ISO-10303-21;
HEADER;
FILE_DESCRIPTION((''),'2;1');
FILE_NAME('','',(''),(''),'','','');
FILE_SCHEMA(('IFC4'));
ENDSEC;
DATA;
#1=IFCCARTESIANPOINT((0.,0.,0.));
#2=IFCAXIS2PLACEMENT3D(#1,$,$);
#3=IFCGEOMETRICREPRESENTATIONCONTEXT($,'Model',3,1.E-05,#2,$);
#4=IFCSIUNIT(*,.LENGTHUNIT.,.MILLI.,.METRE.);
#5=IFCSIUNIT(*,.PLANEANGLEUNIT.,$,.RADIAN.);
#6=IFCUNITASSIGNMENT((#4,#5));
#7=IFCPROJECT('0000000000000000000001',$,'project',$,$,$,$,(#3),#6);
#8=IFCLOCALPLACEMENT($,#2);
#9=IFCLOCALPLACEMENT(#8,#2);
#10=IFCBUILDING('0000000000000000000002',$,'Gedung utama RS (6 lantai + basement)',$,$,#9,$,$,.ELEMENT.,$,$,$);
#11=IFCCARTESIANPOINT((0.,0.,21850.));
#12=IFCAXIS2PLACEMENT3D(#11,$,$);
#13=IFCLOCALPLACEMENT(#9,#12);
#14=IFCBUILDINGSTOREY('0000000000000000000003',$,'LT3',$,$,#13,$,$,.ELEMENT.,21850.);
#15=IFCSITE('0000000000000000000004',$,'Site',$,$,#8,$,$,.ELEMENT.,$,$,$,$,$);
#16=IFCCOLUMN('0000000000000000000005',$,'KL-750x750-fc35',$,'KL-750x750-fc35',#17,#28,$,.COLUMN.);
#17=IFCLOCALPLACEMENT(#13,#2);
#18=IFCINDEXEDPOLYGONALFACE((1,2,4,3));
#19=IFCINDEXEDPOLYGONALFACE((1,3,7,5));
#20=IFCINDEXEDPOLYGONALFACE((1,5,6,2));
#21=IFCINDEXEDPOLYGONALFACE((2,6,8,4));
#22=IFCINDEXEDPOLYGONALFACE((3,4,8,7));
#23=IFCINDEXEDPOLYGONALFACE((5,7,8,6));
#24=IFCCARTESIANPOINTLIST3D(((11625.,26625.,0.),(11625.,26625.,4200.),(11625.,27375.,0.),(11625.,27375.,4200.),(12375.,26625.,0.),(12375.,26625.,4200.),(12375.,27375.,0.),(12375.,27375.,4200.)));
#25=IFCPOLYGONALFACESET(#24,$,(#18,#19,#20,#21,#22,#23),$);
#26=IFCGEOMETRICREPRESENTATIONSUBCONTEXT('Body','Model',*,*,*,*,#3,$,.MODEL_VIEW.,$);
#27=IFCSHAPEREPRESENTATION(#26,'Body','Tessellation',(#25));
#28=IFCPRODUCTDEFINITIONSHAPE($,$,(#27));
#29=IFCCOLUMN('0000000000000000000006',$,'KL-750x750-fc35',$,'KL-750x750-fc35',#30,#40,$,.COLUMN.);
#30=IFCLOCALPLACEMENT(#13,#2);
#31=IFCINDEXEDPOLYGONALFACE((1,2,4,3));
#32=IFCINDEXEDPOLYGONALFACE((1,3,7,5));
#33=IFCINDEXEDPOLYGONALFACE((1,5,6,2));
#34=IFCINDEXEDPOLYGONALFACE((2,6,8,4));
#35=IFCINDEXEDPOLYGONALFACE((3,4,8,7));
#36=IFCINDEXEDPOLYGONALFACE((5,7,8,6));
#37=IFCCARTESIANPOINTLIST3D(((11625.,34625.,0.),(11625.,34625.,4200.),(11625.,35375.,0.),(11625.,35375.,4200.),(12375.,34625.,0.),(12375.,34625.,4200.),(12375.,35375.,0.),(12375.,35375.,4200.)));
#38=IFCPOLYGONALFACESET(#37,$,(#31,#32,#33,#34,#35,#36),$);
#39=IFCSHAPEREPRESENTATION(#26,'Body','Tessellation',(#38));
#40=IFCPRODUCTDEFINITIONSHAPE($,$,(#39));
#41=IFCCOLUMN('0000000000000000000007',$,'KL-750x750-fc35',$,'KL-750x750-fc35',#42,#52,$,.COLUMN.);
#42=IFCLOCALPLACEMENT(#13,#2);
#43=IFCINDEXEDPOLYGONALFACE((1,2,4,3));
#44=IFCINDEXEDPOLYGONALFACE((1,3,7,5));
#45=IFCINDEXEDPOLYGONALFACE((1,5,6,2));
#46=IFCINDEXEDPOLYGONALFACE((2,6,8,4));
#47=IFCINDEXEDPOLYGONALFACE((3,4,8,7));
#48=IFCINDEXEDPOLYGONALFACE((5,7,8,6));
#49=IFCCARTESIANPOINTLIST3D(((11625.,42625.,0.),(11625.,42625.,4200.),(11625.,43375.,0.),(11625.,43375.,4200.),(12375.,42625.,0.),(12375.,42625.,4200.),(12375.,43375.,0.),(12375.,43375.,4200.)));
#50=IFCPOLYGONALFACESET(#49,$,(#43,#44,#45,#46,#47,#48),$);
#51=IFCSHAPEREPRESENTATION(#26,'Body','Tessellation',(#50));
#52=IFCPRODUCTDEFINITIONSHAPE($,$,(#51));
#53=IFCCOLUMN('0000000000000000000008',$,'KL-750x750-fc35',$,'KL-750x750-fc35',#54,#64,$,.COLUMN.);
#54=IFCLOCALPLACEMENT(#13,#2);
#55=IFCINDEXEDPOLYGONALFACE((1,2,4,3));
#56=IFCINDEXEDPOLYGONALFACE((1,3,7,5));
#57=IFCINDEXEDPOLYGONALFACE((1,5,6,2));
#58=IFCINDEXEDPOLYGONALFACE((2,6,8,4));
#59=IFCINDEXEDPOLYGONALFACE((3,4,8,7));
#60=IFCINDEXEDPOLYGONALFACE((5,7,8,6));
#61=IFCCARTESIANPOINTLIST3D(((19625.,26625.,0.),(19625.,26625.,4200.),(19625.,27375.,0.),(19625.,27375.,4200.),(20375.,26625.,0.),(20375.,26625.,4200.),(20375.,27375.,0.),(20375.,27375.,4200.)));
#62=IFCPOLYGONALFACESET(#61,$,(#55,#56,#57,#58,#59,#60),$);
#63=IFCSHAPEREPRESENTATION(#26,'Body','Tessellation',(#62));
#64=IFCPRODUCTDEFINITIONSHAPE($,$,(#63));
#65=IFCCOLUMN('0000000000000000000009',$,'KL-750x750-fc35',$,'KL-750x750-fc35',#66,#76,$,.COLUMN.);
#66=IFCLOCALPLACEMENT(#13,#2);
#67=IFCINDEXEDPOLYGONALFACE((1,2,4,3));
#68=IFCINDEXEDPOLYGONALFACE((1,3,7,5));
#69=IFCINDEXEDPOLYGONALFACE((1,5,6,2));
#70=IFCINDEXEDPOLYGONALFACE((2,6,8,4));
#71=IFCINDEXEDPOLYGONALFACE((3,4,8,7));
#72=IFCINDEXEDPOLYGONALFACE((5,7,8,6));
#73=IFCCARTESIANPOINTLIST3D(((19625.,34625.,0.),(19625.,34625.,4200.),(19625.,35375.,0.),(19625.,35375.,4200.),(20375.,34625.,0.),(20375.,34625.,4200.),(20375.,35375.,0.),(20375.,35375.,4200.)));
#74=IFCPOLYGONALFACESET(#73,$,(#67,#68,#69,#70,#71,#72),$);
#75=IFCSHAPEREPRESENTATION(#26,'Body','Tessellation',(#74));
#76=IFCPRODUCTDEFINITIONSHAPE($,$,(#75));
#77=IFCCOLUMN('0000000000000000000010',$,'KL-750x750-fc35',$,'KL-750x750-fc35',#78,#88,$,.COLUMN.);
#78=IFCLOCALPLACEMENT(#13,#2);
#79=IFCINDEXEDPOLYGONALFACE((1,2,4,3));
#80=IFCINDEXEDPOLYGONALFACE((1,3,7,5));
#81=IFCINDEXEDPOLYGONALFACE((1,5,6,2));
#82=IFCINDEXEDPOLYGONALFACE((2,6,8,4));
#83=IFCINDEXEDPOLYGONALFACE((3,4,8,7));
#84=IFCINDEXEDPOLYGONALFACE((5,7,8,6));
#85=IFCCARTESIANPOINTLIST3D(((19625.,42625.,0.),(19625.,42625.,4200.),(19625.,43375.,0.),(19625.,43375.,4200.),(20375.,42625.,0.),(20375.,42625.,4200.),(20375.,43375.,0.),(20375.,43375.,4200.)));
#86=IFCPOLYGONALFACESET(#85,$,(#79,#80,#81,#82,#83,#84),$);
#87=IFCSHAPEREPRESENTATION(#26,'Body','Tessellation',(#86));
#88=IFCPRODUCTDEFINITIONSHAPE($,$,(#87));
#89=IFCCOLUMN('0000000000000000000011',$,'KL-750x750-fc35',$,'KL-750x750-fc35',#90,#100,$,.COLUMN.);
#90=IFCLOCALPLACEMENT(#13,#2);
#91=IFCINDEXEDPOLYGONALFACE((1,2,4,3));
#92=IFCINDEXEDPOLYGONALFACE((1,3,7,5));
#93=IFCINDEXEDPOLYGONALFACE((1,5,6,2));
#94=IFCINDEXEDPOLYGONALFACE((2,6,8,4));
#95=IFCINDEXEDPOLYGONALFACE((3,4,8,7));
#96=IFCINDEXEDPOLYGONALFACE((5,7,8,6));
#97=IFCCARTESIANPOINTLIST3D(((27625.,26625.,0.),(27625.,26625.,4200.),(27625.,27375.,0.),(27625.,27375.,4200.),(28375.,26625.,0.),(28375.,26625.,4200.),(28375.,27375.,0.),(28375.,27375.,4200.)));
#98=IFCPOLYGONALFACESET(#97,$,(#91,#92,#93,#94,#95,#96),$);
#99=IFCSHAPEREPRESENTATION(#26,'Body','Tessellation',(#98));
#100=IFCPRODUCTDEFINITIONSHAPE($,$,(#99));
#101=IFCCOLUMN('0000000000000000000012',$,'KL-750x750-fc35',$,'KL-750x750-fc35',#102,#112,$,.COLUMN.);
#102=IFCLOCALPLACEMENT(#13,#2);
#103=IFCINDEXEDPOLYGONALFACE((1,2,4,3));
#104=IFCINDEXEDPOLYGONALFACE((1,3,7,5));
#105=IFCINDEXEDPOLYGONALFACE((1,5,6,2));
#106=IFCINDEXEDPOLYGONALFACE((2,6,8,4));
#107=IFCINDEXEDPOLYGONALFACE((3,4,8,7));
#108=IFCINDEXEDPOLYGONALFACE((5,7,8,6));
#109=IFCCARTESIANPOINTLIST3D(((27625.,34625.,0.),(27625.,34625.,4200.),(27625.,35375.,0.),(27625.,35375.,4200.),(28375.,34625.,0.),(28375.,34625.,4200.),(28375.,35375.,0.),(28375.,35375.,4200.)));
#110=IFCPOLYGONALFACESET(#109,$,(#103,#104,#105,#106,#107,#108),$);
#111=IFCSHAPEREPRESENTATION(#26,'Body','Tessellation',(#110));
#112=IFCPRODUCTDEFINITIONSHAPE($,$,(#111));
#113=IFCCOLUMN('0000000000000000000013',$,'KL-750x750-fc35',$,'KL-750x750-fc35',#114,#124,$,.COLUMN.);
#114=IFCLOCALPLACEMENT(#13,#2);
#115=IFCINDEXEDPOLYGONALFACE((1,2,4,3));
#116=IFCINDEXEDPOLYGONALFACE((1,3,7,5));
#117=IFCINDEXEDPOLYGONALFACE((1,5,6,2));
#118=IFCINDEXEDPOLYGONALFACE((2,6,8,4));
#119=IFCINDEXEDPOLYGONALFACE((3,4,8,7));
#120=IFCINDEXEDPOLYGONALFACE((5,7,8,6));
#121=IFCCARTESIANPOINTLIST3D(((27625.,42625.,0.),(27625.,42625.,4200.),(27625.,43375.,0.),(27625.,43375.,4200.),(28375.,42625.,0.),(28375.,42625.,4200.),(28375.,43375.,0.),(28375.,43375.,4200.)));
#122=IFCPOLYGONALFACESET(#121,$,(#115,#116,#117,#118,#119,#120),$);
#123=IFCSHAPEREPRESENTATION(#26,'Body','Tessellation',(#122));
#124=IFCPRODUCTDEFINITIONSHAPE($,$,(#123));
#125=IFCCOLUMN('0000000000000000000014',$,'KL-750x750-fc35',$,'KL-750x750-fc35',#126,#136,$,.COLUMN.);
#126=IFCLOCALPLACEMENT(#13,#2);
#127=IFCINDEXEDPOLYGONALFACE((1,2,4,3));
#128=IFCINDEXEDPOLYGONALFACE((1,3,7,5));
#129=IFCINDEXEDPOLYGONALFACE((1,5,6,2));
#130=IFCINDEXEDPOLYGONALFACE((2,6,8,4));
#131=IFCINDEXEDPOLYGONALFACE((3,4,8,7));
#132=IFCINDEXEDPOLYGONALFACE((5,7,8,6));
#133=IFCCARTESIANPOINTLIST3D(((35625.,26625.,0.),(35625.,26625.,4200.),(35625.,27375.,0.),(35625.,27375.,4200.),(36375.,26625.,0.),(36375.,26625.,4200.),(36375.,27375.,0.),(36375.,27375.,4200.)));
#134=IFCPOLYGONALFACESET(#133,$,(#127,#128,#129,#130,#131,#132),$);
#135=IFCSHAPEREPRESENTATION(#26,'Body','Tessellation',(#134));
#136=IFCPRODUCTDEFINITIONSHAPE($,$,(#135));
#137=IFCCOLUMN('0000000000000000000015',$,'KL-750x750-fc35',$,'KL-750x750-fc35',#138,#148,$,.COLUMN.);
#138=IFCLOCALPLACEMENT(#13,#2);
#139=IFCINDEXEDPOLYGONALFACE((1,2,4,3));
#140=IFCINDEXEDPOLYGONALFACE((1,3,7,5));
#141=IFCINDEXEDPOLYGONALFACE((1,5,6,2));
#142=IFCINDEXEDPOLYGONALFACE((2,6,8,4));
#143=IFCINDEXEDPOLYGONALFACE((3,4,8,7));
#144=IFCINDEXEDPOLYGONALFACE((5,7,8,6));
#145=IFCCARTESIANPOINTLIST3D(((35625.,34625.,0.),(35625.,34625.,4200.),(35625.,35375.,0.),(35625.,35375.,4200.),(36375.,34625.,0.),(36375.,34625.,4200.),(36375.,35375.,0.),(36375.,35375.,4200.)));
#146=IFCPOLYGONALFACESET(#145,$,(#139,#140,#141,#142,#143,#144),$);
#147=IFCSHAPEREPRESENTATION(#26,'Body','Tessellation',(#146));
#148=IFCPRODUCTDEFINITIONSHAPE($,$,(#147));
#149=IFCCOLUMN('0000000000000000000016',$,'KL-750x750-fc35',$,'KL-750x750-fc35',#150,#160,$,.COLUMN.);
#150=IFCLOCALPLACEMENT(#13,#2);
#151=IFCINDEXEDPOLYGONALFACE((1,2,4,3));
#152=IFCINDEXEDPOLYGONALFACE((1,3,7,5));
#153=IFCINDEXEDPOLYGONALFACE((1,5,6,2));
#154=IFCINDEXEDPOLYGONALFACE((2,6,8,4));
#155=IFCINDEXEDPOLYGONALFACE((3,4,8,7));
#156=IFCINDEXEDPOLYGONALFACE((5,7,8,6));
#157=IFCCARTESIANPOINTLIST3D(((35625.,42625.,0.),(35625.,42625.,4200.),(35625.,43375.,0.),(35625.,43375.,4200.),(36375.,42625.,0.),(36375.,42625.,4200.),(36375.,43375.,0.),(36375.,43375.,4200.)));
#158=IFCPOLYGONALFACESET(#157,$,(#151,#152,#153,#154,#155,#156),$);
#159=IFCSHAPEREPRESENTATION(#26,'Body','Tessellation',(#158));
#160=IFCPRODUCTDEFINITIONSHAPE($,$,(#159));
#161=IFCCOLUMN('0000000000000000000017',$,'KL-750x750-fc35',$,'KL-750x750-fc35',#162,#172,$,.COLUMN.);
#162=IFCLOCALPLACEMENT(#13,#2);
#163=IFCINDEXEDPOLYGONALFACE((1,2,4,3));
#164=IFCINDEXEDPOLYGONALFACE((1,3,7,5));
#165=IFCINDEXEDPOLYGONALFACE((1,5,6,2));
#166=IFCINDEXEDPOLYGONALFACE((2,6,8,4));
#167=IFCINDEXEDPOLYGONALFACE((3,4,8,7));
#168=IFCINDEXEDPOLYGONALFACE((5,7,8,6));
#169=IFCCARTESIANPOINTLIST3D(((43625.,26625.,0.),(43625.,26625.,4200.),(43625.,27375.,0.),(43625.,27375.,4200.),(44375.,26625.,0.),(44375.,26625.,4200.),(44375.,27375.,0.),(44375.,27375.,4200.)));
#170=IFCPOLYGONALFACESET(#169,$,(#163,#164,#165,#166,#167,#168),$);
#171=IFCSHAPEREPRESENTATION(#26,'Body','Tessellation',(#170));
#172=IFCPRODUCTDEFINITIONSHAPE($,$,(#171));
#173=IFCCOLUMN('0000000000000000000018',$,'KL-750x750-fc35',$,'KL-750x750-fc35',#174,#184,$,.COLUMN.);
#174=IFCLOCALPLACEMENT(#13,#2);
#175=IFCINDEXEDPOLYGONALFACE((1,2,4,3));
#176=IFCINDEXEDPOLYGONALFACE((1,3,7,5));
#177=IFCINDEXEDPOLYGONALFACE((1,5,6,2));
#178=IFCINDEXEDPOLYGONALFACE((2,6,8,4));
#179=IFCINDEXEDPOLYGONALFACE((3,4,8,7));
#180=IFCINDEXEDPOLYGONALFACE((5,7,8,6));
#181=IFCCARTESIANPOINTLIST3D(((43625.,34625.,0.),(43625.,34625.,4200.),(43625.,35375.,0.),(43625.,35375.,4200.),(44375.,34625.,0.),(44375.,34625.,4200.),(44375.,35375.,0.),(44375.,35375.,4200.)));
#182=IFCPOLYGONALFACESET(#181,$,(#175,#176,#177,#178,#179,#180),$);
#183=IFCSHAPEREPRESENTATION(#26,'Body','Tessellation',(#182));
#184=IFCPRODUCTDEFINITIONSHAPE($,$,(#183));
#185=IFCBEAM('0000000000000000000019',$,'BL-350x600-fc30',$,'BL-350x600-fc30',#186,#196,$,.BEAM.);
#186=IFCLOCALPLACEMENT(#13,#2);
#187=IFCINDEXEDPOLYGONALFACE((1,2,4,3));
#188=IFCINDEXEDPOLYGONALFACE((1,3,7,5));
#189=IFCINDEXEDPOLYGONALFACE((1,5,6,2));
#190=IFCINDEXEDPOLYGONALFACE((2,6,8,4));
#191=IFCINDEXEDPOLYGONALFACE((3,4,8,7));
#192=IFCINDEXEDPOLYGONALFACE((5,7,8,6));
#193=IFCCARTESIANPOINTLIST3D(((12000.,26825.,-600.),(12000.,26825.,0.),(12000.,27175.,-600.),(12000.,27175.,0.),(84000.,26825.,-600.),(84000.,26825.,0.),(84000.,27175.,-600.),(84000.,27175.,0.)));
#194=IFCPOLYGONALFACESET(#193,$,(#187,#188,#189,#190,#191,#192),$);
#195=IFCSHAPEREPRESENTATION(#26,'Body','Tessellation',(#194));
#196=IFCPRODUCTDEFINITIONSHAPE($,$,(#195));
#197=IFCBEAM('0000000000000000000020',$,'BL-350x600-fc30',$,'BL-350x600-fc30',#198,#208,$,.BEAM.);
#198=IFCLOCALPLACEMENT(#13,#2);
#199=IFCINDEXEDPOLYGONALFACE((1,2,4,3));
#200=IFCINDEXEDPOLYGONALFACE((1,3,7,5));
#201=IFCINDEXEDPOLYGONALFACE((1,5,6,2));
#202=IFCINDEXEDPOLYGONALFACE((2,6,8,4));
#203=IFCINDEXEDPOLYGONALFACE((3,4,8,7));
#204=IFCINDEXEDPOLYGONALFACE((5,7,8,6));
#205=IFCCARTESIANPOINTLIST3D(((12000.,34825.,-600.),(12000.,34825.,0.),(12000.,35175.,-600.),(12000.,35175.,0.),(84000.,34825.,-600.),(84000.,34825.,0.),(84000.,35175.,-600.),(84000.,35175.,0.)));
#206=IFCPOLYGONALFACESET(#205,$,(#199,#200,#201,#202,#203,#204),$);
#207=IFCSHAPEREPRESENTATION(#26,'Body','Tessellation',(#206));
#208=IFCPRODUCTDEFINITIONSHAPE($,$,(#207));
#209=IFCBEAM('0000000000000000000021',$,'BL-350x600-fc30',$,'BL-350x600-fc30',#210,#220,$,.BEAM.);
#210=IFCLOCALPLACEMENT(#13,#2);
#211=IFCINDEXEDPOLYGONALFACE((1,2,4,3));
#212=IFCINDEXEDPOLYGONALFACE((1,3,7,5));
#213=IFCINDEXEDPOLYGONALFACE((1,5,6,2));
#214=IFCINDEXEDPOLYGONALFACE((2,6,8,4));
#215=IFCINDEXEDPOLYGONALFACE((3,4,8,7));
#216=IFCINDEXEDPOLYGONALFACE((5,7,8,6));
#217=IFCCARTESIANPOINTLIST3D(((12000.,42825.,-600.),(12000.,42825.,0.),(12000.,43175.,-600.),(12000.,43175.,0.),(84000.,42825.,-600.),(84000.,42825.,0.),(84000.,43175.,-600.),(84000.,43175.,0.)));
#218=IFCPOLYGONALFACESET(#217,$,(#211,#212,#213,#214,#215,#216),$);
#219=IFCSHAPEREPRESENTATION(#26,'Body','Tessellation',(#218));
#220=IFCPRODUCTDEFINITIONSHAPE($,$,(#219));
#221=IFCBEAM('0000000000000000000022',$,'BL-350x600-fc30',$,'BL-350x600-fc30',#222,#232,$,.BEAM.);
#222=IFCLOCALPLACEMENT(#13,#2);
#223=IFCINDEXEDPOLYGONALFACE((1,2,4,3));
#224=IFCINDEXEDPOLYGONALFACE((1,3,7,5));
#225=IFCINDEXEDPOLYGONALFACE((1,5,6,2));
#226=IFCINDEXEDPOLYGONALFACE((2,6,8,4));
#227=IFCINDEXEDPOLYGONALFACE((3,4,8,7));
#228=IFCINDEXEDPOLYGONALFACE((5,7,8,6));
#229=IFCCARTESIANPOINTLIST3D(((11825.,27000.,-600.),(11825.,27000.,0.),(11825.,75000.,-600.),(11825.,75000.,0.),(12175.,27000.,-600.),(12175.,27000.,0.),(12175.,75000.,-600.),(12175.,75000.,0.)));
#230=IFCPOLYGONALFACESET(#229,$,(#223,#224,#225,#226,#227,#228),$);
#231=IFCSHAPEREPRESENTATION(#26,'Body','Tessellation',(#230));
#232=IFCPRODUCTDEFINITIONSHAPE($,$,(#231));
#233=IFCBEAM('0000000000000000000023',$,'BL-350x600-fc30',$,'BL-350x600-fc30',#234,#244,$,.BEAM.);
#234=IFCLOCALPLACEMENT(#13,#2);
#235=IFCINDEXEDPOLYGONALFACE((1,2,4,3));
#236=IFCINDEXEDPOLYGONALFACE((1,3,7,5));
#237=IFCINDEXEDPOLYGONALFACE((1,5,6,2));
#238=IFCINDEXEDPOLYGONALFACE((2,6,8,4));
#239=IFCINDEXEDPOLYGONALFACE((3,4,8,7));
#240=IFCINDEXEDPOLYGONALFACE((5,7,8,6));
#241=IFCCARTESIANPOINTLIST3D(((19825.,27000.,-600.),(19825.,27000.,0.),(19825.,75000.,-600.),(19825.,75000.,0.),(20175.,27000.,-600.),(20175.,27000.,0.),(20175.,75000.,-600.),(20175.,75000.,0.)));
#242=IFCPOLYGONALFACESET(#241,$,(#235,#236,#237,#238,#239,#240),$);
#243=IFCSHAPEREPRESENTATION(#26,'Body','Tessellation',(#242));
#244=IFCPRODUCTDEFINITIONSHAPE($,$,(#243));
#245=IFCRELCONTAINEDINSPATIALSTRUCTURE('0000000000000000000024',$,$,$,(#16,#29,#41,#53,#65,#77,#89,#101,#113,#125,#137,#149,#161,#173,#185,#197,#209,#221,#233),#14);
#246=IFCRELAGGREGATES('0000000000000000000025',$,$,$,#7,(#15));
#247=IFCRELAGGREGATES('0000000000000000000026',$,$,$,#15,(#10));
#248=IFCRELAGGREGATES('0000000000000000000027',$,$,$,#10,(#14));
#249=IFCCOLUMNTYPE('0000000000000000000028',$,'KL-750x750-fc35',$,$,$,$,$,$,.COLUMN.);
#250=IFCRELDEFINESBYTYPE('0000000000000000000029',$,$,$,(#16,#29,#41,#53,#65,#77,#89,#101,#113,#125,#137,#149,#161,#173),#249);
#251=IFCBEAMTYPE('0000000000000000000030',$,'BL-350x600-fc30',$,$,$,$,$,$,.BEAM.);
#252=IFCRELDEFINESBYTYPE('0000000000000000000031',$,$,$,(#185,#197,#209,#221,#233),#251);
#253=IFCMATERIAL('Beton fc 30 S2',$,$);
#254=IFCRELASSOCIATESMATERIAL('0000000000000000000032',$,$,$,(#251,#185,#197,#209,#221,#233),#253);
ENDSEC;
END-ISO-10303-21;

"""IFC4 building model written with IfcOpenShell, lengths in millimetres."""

from ifc_helpers import new_model, si_unit, frame, origin, origin_2d, place, context, subcontext, project, spatial, rectangle, extrude, material, material_profile, profile_set, profile_usage, type_object, element, save


model = new_model("IFC4")

# Units and contexts
model_context = context("Model", 3, precision=1e-05, world=origin())
body_context = subcontext(model_context, "Body", "Model", "MODEL_VIEW")
ifc_project = project(units=[si_unit("LENGTHUNIT", "METRE", prefix="MILLI"), si_unit("PLANEANGLEUNIT", "RADIAN")], contexts=[model_context])

# Site, building, storey
site_placement = place(None, origin())
site = spatial("IfcSite", under=ifc_project, at=site_placement, Name="Site", CompositionType="ELEMENT")
building_placement = place(site_placement, origin())
building = spatial("IfcBuilding", under=site, at=building_placement, Name="Gedung utama RS (6 lantai + basement)", CompositionType="ELEMENT")
storey_placement = place(building_placement, frame((0.0, 0.0, 21850.0)))
storey = spatial("IfcBuildingStorey", under=building, at=storey_placement, Name="LT3", CompositionType="ELEMENT", Elevation=21850.0)

# Columns
ifc_material_profile_1 = material_profile(None, rectangle(XDim=750.0, YDim=750.0, at=origin_2d()), Name="KL-750x750-fc35")
ifc_profile_set_1 = profile_set([ifc_material_profile_1], Name="KL-750x750-fc35")
ifc_profile_usage_1 = profile_usage(ifc_profile_set_1, cardinal=5)
column_type = type_object("IfcColumnType", Name="KL-750x750-fc35", PredefinedType="COLUMN", material=ifc_profile_set_1)
for number, where, z_axis, x_axis, name in (
    (1, (12000.0, 27000.0, 0.0), (0.0, 0.0, 1.0), (1.0, 0.0, 0.0), "KL-750x750-fc35"),
    (2, (12000.0, 35000.0, 0.0), (0.0, 0.0, 1.0), (1.0, 0.0, 0.0), "KL-750x750-fc35"),
    (3, (12000.0, 43000.0, 0.0), (0.0, 0.0, 1.0), (1.0, 0.0, 0.0), "KL-750x750-fc35"),
    (4, (20000.0, 27000.0, 0.0), (0.0, 0.0, 1.0), (1.0, 0.0, 0.0), "KL-750x750-fc35"),
    (5, (20000.0, 35000.0, 0.0), (0.0, 0.0, 1.0), (1.0, 0.0, 0.0), "KL-750x750-fc35"),
    (6, (20000.0, 43000.0, 0.0), (0.0, 0.0, 1.0), (1.0, 0.0, 0.0), "KL-750x750-fc35"),
    (7, (28000.0, 27000.0, 0.0), (0.0, 0.0, 1.0), (1.0, 0.0, 0.0), "KL-750x750-fc35"),
    (8, (28000.0, 35000.0, 0.0), (0.0, 0.0, 1.0), (1.0, 0.0, 0.0), "KL-750x750-fc35"),
    (9, (28000.0, 43000.0, 0.0), (0.0, 0.0, 1.0), (1.0, 0.0, 0.0), "KL-750x750-fc35"),
    (10, (36000.0, 27000.0, 0.0), (0.0, 0.0, 1.0), (1.0, 0.0, 0.0), "KL-750x750-fc35"),
    (11, (36000.0, 35000.0, 0.0), (0.0, 0.0, 1.0), (1.0, 0.0, 0.0), "KL-750x750-fc35"),
    (12, (36000.0, 43000.0, 0.0), (0.0, 0.0, 1.0), (1.0, 0.0, 0.0), "KL-750x750-fc35"),
    (13, (44000.0, 27000.0, 0.0), (0.0, 0.0, 1.0), (1.0, 0.0, 0.0), "KL-750x750-fc35"),
    (14, (44000.0, 35000.0, 0.0), (0.0, 0.0, 1.0), (1.0, 0.0, 0.0), "KL-750x750-fc35"),
):
    element("IfcColumn", number, at=place(storey_placement, frame(where, z_axis=z_axis, x_axis=x_axis)), inside=storey, type_object=column_type, material=ifc_profile_usage_1, Name=name, ObjectType="KL-750x750-fc35", PredefinedType="COLUMN", context=body_context, shape_type="SweptSolid", body=[
        extrude(rectangle(XDim=750.0, YDim=750.0, at=origin_2d()), origin(), (0.0, 0.0, 1.0), 4200.0),
    ])

# Beams
ifc_material = material(Name="Beton fc 30 S2")
ifc_material_profile_2 = material_profile(ifc_material, rectangle(XDim=350.0, YDim=600.0, at=origin_2d()), Name="BL-350x600-fc30")
ifc_profile_set_2 = profile_set([ifc_material_profile_2], Name="BL-350x600-fc30")
ifc_profile_usage_2 = profile_usage(ifc_profile_set_2, cardinal=8)
beam_type = type_object("IfcBeamType", Name="BL-350x600-fc30", PredefinedType="BEAM", material=ifc_profile_set_2)
for number, where, name in (
    (15, (12000.0, 27000.0, -300.0), "BL-350x600-fc30"),
    (16, (12000.0, 35000.0, -300.0), "BL-350x600-fc30"),
    (17, (12000.0, 43000.0, -300.0), "BL-350x600-fc30"),
):
    element("IfcBeam", number, at=place(storey_placement, frame(where)), inside=storey, type_object=beam_type, material=ifc_profile_usage_2, Name=name, ObjectType="BL-350x600-fc30", PredefinedType="BEAM", context=body_context, shape_type="SweptSolid", body=[
        extrude(rectangle(XDim=350.0, YDim=600.0, at=origin_2d()), frame((0.0, 0.0, 0.0), z_axis=(1.0, 0.0, 0.0), x_axis=(0.0, 1.0, 0.0)), (0.0, 0.0, 1.0), 72000.0),
    ])
for number, where, name in (
    (18, (12000.0, 27000.0, -300.0), "BL-350x600-fc30"),
    (19, (20000.0, 27000.0, -300.0), "BL-350x600-fc30"),
):
    element("IfcBeam", number, at=place(storey_placement, frame(where)), inside=storey, type_object=beam_type, material=ifc_profile_usage_2, Name=name, ObjectType="BL-350x600-fc30", PredefinedType="BEAM", context=body_context, shape_type="SweptSolid", body=[
        extrude(rectangle(XDim=350.0, YDim=600.0, at=origin_2d()), frame((0.0, 0.0, 0.0), z_axis=(0.0, 1.0, 0.0), x_axis=(-1.0, 0.0, 0.0)), (0.0, 0.0, 1.0), 48000.0),
    ])

save(model, "model.ifc")
